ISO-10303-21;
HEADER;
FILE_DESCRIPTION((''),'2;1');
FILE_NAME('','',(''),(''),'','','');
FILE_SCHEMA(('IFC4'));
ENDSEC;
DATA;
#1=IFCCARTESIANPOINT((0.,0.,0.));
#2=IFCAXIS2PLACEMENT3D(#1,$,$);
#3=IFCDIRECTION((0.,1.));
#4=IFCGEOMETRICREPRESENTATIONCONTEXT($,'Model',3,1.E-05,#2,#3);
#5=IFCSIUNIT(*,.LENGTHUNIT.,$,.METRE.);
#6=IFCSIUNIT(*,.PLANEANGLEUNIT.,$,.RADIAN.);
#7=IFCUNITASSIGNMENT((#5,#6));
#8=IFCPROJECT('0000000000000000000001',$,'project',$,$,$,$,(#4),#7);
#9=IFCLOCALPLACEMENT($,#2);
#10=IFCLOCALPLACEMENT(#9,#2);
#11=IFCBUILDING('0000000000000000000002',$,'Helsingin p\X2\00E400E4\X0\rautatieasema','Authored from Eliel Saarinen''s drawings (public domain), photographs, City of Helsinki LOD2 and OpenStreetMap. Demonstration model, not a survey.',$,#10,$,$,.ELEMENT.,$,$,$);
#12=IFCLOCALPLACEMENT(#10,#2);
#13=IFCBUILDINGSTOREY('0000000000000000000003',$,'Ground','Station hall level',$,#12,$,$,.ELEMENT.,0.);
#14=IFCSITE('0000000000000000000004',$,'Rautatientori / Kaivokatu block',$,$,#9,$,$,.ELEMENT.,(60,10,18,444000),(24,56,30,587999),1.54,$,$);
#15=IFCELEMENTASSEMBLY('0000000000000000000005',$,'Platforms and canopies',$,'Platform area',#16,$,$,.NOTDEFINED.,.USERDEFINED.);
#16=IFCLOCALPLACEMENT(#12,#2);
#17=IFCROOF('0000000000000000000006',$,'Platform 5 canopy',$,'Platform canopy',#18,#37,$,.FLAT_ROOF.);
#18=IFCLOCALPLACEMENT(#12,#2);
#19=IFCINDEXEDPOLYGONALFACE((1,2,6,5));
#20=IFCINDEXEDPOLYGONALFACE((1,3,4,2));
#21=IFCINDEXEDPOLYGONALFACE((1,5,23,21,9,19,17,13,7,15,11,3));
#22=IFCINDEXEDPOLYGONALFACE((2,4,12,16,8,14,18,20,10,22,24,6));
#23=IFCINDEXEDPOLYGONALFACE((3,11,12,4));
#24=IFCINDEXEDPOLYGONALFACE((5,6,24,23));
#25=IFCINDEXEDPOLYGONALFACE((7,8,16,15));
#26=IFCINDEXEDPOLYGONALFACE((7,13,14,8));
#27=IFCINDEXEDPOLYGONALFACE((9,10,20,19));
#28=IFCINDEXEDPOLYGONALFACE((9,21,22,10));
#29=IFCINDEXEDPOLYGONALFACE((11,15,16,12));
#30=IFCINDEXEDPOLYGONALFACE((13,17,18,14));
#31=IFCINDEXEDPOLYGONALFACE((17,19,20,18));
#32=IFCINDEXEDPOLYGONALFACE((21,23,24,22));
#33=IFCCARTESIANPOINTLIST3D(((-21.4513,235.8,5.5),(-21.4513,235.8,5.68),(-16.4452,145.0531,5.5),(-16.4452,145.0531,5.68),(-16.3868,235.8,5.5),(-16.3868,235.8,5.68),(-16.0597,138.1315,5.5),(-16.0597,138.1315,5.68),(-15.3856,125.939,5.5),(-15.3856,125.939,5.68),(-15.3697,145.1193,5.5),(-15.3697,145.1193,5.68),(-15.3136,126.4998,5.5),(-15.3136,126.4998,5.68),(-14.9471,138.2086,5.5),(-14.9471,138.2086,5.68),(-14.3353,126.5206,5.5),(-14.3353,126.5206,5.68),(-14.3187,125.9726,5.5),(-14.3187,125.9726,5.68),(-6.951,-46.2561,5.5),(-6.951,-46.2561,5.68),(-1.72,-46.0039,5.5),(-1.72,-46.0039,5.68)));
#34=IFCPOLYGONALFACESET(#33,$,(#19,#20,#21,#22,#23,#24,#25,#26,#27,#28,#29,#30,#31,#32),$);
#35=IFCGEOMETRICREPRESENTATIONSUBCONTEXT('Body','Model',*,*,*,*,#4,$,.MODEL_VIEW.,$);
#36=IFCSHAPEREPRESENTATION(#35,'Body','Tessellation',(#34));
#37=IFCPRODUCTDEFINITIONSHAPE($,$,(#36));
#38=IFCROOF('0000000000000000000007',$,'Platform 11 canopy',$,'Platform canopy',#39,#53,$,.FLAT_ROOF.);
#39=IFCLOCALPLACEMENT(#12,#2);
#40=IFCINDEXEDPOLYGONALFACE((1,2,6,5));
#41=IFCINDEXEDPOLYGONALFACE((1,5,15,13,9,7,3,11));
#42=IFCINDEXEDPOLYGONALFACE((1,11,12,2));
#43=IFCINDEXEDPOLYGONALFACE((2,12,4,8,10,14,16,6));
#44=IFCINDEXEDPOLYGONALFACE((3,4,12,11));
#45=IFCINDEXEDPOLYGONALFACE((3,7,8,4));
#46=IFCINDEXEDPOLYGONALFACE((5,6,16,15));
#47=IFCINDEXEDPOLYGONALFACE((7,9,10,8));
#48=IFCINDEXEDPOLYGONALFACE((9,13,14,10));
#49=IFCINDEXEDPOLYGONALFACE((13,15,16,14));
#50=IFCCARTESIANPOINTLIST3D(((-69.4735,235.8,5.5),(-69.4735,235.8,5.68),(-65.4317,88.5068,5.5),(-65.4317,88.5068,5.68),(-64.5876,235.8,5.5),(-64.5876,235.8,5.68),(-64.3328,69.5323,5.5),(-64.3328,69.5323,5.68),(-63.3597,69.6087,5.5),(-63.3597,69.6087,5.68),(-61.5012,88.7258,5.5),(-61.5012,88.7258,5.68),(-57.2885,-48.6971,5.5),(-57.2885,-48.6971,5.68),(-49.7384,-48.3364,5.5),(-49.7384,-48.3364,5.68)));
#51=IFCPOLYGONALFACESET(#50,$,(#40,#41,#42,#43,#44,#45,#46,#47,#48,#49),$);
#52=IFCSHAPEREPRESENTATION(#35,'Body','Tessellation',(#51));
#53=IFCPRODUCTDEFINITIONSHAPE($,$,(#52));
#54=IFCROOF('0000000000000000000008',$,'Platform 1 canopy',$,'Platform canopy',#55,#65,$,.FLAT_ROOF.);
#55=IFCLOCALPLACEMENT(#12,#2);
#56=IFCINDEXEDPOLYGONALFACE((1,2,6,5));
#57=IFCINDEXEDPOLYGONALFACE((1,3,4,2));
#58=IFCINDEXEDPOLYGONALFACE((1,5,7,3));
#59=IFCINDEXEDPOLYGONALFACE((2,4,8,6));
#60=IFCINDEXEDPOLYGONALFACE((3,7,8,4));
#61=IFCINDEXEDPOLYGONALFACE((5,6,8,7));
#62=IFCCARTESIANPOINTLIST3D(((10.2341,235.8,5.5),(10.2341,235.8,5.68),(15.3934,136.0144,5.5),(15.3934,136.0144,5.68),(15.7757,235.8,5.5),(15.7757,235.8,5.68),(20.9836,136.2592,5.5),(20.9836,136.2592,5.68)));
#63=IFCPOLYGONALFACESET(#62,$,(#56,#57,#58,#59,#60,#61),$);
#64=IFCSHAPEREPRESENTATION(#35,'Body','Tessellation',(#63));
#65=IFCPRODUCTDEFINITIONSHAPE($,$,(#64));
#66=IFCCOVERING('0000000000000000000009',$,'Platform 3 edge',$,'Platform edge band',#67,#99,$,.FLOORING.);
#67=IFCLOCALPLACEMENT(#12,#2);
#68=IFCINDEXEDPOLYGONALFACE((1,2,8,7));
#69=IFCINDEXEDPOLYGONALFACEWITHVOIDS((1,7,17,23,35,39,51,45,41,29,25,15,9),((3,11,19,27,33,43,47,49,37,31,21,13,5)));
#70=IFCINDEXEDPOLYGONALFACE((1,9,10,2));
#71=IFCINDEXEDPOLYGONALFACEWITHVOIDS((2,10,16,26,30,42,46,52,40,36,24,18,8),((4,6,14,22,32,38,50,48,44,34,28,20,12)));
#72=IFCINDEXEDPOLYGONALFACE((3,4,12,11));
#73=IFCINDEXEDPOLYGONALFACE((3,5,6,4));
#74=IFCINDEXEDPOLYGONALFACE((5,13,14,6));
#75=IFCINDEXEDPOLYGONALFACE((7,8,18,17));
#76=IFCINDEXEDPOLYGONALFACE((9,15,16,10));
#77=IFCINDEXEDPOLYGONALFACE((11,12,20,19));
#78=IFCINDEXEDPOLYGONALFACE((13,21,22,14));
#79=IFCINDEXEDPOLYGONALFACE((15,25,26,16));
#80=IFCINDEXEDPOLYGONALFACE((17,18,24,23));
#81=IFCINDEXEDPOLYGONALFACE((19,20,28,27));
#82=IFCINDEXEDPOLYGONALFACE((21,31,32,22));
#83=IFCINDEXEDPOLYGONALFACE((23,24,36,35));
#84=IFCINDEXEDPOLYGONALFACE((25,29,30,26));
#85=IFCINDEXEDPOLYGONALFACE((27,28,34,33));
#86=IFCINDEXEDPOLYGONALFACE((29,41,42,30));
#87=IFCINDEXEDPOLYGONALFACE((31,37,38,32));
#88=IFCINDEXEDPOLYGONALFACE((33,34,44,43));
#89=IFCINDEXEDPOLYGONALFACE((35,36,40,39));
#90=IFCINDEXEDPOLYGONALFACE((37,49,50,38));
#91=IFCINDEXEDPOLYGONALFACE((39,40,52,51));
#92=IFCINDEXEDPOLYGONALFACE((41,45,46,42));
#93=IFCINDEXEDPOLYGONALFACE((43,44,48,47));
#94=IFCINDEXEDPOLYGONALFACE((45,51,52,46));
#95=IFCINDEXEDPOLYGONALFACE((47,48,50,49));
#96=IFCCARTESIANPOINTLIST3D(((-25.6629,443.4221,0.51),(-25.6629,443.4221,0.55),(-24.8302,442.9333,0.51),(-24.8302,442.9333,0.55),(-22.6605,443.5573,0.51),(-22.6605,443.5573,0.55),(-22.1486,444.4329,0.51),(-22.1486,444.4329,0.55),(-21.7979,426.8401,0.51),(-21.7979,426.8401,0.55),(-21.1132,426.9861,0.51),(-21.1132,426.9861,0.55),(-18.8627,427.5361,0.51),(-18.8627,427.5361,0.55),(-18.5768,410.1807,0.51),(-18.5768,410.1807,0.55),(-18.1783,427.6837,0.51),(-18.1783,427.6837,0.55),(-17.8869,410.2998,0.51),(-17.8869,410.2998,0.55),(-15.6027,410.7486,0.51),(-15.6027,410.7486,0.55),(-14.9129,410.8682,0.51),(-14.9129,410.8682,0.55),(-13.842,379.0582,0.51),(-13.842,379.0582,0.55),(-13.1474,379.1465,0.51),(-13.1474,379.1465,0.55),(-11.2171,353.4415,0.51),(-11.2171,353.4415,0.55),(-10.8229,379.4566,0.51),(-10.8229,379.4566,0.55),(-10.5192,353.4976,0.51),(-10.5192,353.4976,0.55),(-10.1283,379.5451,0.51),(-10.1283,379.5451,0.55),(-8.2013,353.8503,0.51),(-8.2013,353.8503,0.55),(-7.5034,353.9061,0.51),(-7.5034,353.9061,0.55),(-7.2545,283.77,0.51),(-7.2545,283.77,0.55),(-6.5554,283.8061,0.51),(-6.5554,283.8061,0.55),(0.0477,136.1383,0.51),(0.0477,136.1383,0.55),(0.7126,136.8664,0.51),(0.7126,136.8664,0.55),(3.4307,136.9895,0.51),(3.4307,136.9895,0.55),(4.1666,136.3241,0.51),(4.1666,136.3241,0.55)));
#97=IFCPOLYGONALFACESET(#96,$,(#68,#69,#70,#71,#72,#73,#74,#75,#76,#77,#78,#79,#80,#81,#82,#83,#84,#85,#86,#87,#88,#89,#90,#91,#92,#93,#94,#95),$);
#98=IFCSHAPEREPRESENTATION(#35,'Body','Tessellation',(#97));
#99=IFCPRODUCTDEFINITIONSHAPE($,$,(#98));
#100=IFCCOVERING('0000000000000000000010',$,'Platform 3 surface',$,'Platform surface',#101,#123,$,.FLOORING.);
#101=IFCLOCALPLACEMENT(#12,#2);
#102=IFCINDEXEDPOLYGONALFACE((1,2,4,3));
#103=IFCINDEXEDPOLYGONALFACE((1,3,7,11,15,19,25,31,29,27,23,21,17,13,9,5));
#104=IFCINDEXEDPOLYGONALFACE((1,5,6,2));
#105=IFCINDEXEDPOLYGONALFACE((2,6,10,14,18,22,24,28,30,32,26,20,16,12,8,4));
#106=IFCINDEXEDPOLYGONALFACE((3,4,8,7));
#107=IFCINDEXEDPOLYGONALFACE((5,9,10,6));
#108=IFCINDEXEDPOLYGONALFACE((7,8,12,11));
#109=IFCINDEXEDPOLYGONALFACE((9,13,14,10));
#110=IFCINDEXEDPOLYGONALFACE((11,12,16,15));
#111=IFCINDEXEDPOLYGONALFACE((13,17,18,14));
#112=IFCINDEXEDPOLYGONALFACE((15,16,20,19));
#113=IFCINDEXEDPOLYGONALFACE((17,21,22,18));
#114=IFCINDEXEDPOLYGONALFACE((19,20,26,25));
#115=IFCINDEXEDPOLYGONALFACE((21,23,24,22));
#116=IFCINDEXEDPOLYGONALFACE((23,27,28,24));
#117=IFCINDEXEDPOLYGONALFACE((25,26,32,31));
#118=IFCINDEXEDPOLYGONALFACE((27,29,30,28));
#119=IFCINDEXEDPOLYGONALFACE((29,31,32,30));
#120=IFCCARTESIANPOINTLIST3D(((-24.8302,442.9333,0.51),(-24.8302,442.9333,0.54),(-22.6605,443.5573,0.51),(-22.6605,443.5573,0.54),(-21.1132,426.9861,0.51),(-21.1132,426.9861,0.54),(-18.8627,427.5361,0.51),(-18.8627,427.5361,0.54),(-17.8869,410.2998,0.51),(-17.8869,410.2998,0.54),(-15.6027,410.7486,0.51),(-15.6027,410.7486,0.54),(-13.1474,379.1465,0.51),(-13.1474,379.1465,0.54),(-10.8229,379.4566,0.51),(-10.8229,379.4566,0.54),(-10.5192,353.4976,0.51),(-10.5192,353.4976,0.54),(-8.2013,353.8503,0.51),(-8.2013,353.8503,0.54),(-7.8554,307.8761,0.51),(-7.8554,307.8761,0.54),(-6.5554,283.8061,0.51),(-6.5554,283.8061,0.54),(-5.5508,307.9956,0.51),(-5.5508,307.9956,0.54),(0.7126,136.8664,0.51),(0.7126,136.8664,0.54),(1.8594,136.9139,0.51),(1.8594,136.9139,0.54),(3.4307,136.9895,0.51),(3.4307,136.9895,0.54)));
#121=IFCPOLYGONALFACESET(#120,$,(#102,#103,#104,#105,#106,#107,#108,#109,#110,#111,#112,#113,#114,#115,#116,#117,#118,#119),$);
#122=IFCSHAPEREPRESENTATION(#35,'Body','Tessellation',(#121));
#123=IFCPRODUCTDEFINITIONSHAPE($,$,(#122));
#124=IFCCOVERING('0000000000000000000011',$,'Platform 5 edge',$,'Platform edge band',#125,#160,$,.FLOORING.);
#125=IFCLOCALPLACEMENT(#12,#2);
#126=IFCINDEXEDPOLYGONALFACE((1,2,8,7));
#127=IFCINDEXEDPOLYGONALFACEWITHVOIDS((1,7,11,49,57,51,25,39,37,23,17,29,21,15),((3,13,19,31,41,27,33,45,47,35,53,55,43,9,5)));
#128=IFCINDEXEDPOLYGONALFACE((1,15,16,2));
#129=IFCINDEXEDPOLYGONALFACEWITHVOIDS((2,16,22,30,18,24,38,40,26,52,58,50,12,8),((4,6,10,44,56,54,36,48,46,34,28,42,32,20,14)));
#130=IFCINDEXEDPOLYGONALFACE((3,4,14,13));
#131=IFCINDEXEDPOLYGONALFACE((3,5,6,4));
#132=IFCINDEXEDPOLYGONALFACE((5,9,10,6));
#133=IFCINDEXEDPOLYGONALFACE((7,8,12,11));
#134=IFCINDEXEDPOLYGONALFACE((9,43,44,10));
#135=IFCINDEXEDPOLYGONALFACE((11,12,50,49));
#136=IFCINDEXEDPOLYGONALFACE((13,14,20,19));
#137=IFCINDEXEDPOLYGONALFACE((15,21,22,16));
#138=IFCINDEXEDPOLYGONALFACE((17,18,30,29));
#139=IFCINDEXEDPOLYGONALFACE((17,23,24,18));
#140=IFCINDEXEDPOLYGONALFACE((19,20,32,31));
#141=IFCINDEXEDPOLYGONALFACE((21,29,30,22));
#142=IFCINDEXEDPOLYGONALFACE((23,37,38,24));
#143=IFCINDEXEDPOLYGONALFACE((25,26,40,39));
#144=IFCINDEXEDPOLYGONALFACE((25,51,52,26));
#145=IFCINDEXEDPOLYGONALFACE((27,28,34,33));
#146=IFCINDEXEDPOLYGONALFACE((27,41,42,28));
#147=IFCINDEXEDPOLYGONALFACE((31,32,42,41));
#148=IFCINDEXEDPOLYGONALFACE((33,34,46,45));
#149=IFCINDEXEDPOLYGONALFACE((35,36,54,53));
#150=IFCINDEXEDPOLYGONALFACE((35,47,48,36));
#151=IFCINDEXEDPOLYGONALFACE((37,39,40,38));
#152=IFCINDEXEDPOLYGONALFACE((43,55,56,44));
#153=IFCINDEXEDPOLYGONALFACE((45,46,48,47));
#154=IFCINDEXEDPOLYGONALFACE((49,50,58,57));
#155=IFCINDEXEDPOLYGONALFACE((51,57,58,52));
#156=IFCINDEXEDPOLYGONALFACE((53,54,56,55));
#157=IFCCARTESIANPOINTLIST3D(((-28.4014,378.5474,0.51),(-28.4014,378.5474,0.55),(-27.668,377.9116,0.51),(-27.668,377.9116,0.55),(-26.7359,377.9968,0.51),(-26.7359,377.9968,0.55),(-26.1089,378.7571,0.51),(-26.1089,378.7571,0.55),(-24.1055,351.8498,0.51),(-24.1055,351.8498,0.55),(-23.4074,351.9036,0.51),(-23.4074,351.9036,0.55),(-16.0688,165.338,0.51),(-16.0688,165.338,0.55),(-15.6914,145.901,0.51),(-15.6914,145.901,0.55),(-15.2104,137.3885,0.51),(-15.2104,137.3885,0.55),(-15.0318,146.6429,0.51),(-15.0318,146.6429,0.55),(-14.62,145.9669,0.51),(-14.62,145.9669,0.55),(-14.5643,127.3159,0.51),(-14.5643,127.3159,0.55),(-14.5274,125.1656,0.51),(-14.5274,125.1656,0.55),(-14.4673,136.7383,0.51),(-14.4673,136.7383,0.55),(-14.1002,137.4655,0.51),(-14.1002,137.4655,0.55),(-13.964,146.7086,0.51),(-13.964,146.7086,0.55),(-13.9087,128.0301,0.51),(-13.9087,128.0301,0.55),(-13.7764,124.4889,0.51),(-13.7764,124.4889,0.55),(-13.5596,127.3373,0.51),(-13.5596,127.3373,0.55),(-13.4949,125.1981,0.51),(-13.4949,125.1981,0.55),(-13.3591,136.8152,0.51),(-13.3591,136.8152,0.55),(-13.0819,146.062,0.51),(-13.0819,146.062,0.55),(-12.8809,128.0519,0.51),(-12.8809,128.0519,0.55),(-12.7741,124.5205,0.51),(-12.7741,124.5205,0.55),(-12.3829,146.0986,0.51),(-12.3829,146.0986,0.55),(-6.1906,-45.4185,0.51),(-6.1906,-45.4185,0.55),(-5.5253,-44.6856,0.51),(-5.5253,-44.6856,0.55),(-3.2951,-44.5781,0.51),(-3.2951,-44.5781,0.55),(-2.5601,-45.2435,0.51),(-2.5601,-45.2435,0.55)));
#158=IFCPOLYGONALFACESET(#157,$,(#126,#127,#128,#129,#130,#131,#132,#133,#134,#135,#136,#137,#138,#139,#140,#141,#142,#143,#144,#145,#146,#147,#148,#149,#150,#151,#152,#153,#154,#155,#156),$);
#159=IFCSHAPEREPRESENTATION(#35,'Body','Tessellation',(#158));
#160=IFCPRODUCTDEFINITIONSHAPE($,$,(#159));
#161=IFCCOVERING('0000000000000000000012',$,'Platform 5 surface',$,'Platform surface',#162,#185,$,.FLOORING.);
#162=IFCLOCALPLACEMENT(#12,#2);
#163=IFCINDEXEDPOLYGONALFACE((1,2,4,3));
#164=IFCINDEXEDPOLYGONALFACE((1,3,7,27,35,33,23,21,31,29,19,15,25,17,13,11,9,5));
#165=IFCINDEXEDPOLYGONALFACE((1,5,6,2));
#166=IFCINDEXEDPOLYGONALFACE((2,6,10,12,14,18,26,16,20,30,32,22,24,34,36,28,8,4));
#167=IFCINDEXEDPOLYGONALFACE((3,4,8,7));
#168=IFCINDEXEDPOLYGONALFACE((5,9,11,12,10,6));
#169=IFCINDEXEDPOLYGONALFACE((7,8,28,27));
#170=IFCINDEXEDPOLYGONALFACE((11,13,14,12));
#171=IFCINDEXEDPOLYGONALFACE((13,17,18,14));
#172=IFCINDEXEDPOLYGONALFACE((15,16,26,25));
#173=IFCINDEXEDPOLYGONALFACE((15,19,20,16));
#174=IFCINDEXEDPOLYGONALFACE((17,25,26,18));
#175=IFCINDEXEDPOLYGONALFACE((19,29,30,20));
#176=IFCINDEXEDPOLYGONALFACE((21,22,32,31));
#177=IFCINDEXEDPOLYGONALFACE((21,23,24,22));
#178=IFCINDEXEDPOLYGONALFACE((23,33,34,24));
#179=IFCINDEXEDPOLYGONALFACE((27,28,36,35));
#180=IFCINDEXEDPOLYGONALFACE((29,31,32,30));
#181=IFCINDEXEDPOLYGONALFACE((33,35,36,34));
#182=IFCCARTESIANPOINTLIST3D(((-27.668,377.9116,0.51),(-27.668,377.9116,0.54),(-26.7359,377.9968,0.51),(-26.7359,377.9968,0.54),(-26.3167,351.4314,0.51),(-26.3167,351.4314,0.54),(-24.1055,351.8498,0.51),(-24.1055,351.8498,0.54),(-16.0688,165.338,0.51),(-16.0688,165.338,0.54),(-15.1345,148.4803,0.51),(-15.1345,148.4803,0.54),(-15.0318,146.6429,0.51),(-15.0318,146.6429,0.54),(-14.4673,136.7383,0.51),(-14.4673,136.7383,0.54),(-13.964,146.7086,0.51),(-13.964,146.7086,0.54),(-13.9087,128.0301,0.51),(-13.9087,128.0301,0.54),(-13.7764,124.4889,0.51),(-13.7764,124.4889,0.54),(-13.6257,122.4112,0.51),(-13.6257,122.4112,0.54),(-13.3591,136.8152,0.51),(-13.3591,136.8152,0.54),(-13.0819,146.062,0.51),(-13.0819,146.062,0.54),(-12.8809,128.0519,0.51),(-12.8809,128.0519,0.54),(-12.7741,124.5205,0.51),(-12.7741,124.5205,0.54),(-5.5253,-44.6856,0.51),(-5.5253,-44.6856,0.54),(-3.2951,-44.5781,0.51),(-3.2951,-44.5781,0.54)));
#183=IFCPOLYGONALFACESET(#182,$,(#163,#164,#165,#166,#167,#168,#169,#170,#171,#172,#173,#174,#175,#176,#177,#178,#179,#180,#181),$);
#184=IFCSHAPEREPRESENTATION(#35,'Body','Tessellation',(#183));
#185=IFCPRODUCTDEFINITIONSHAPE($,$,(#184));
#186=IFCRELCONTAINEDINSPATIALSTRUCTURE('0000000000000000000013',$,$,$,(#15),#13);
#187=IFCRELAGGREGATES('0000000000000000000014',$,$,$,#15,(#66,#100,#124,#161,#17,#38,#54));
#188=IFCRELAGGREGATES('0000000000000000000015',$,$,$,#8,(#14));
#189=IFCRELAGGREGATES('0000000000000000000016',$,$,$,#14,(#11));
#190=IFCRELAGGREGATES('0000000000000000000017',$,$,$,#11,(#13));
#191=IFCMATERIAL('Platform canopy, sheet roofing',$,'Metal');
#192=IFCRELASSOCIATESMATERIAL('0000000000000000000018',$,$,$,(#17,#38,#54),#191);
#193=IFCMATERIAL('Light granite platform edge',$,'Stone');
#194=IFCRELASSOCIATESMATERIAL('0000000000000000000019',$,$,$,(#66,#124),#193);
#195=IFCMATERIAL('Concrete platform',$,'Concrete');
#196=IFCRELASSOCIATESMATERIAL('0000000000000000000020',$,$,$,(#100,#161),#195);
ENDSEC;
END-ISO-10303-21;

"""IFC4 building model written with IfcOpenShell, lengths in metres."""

from ifc_helpers import new_model, si_unit, direction, frame, origin, place, context, subcontext, project, spatial, polyline, outline, extrude, material, element, aggregate, save


model = new_model("IFC4")

# Units and contexts
model_context = context("Model", 3, precision=1e-05, world=origin(), true_north=direction((0.0, 1.0)))
body_context = subcontext(model_context, "Body", "Model", "MODEL_VIEW")
ifc_project = project(units=[si_unit("LENGTHUNIT", "METRE"), si_unit("PLANEANGLEUNIT", "RADIAN")], contexts=[model_context])

# Site, building, storey
site_placement = place(None, origin())
site = spatial("IfcSite", under=ifc_project, at=site_placement, Name="Rautatientori / Kaivokatu block", CompositionType="ELEMENT", RefLatitude=(60, 10, 18, 444000), RefLongitude=(24, 56, 30, 587999), RefElevation=1.54)
building_placement = place(site_placement, origin())
building = spatial("IfcBuilding", under=site, at=building_placement, Name="Helsingin päärautatieasema", Description="Authored from Eliel Saarinen's drawings (public domain), photographs, City of Helsinki LOD2 and OpenStreetMap. Demonstration model, not a survey.", CompositionType="ELEMENT")
storey_placement = place(building_placement, origin())
storey = spatial("IfcBuildingStorey", under=building, at=storey_placement, Name="Ground", Description="Station hall level", CompositionType="ELEMENT", Elevation=0.0)

# Element assembly, roofs, coverings
assembly_placement = place(building_placement, origin())
assembly = element("IfcElementAssembly", 1, at=assembly_placement, inside=storey, Name="Platforms and canopies", ObjectType="Platform area", AssemblyPlace="NOTDEFINED", PredefinedType="USERDEFINED")
ifc_material_1 = material(Name="Concrete platform", Category="Concrete")
ifc_material_2 = material(Name="Platform canopy, sheet roofing", Category="Metal")
roof_1_placement = place(building_placement, origin())
roof_1 = element("IfcRoof", 2, at=roof_1_placement, material=ifc_material_2, Name="Platform 5 canopy", ObjectType="Platform canopy", PredefinedType="FLAT_ROOF", context=body_context, shape_type="SweptSolid", body=[
    extrude(outline(polyline([(-16.4452, 145.0531), (-21.4513, 235.8), (-16.3868, 235.8), (-1.72, -46.0039), (-6.951, -46.2561), (-15.3856, 125.939), (-14.3187, 125.9726), (-14.3353, 126.5206), (-15.3136, 126.4998), (-16.0597, 138.1315), (-14.9471, 138.2086), (-15.3697, 145.1193), (-16.4452, 145.0531)])), frame((0.0, 0.0, 5.5)), (0.0, 0.0, 1.0), 0.18),
])
roof_2_placement = place(building_placement, origin())
roof_2 = element("IfcRoof", 3, at=roof_2_placement, material=ifc_material_2, Name="Platform 11 canopy", ObjectType="Platform canopy", PredefinedType="FLAT_ROOF", context=body_context, shape_type="SweptSolid", body=[
    extrude(outline(polyline([(-49.7384, -48.3364), (-57.2885, -48.6971), (-63.3597, 69.6087), (-64.3328, 69.5323), (-65.4317, 88.5068), (-61.5012, 88.7258), (-69.4735, 235.8), (-64.5876, 235.8), (-49.7384, -48.3364)])), frame((0.0, 0.0, 5.5)), (0.0, 0.0, 1.0), 0.18),
])
roof_3_placement = place(building_placement, origin())
roof_3 = element("IfcRoof", 4, at=roof_3_placement, material=ifc_material_2, Name="Platform 1 canopy", ObjectType="Platform canopy", PredefinedType="FLAT_ROOF", context=body_context, shape_type="SweptSolid", body=[
    extrude(outline(polyline([(15.3934, 136.0144), (10.2341, 235.8), (15.7757, 235.8), (20.9836, 136.2592), (15.3934, 136.0144)])), frame((0.0, 0.0, 5.5)), (0.0, 0.0, 1.0), 0.18),
])
ifc_material_3 = material(Name="Light granite platform edge", Category="Stone")
covering_1_placement = place(building_placement, origin())
covering_1 = element("IfcCovering", 5, at=covering_1_placement, material=ifc_material_3, Name="Platform 3 edge", ObjectType="Platform edge band", PredefinedType="FLOORING", context=body_context, shape_type="SweptSolid", body=[
    extrude(outline(polyline([(0.0477, 136.1383), (-7.2545, 283.77), (-11.2171, 353.4415), (-13.842, 379.0582), (-18.5768, 410.1807), (-21.7979, 426.8401), (-25.6629, 443.4221), (-22.1486, 444.4329), (-18.1783, 427.6837), (-14.9129, 410.8682), (-10.1283, 379.5451), (-7.5034, 353.9061), (4.1666, 136.3241), (0.0477, 136.1383)]), holes=[polyline([(0.7126, 136.8664), (-6.5554, 283.8061), (-10.5192, 353.4976), (-13.1474, 379.1465), (-17.8869, 410.2998), (-21.1132, 426.9861), (-24.8302, 442.9333), (-22.6605, 443.5573), (-18.8627, 427.5361), (-15.6027, 410.7486), (-10.8229, 379.4566), (-8.2013, 353.8503), (3.4307, 136.9895), (0.7126, 136.8664)])]), frame((0.0, 0.0, 0.51)), (0.0, 0.0, 1.0), 0.04),
])
covering_2_placement = place(building_placement, origin())
covering_2 = element("IfcCovering", 6, at=covering_2_placement, material=ifc_material_1, Name="Platform 3 surface", ObjectType="Platform surface", PredefinedType="FLOORING", context=body_context, shape_type="SweptSolid", body=[
    extrude(outline(polyline([(0.7126, 136.8664), (-6.5554, 283.8061), (-7.8554, 307.8761), (-10.5192, 353.4976), (-13.1474, 379.1465), (-17.8869, 410.2998), (-21.1132, 426.9861), (-24.8302, 442.9333), (-22.6605, 443.5573), (-18.8627, 427.5361), (-15.6027, 410.7486), (-10.8229, 379.4566), (-8.2013, 353.8503), (-5.5508, 307.9956), (3.4307, 136.9895), (1.8594, 136.9139), (0.7126, 136.8664)])), frame((0.0, 0.0, 0.51)), (0.0, 0.0, 1.0), 0.03),
])
covering_3_placement = place(building_placement, origin())
covering_3 = element("IfcCovering", 7, at=covering_3_placement, material=ifc_material_3, Name="Platform 5 edge", ObjectType="Platform edge band", PredefinedType="FLOORING", context=body_context, shape_type="SweptSolid", body=[
    extrude(outline(polyline([(-14.62, 145.9669), (-15.6914, 145.901), (-28.4014, 378.5474), (-26.1089, 378.7571), (-23.4074, 351.9036), (-12.3829, 146.0986), (-2.5601, -45.2435), (-6.1906, -45.4185), (-14.5274, 125.1656), (-13.4949, 125.1981), (-13.5596, 127.3373), (-14.5643, 127.3159), (-15.2104, 137.3885), (-14.1002, 137.4655), (-14.62, 145.9669)]), holes=[polyline([(-13.964, 146.7086), (-15.0318, 146.6429), (-16.0688, 165.338), (-27.668, 377.9116), (-26.7359, 377.9968), (-24.1055, 351.8498), (-13.0819, 146.062), (-3.2951, -44.5781), (-5.5253, -44.6856), (-13.7764, 124.4889), (-12.7741, 124.5205), (-12.8809, 128.0519), (-13.9087, 128.0301), (-14.4673, 136.7383), (-13.3591, 136.8152), (-13.964, 146.7086)])]), frame((0.0, 0.0, 0.51)), (0.0, 0.0, 1.0), 0.04),
])
covering_4_placement = place(building_placement, origin())
covering_4 = element("IfcCovering", 8, at=covering_4_placement, material=ifc_material_1, Name="Platform 5 surface", ObjectType="Platform surface", PredefinedType="FLOORING", context=body_context, shape_type="SweptSolid", body=[
    extrude(outline(polyline([(-13.964, 146.7086), (-15.0318, 146.6429), (-15.1345, 148.4803), (-16.0688, 165.338), (-26.3167, 351.4314), (-27.668, 377.9116), (-26.7359, 377.9968), (-24.1055, 351.8498), (-13.0819, 146.062), (-3.2951, -44.5781), (-5.5253, -44.6856), (-13.6257, 122.4112), (-13.7764, 124.4889), (-12.7741, 124.5205), (-12.8809, 128.0519), (-13.9087, 128.0301), (-14.4673, 136.7383), (-13.3591, 136.8152), (-13.964, 146.7086)])), frame((0.0, 0.0, 0.51)), (0.0, 0.0, 1.0), 0.03),
])
aggregate(assembly, [covering_1, covering_2, covering_3, covering_4, roof_1, roof_2, roof_3])

save(model, "model.ifc")
